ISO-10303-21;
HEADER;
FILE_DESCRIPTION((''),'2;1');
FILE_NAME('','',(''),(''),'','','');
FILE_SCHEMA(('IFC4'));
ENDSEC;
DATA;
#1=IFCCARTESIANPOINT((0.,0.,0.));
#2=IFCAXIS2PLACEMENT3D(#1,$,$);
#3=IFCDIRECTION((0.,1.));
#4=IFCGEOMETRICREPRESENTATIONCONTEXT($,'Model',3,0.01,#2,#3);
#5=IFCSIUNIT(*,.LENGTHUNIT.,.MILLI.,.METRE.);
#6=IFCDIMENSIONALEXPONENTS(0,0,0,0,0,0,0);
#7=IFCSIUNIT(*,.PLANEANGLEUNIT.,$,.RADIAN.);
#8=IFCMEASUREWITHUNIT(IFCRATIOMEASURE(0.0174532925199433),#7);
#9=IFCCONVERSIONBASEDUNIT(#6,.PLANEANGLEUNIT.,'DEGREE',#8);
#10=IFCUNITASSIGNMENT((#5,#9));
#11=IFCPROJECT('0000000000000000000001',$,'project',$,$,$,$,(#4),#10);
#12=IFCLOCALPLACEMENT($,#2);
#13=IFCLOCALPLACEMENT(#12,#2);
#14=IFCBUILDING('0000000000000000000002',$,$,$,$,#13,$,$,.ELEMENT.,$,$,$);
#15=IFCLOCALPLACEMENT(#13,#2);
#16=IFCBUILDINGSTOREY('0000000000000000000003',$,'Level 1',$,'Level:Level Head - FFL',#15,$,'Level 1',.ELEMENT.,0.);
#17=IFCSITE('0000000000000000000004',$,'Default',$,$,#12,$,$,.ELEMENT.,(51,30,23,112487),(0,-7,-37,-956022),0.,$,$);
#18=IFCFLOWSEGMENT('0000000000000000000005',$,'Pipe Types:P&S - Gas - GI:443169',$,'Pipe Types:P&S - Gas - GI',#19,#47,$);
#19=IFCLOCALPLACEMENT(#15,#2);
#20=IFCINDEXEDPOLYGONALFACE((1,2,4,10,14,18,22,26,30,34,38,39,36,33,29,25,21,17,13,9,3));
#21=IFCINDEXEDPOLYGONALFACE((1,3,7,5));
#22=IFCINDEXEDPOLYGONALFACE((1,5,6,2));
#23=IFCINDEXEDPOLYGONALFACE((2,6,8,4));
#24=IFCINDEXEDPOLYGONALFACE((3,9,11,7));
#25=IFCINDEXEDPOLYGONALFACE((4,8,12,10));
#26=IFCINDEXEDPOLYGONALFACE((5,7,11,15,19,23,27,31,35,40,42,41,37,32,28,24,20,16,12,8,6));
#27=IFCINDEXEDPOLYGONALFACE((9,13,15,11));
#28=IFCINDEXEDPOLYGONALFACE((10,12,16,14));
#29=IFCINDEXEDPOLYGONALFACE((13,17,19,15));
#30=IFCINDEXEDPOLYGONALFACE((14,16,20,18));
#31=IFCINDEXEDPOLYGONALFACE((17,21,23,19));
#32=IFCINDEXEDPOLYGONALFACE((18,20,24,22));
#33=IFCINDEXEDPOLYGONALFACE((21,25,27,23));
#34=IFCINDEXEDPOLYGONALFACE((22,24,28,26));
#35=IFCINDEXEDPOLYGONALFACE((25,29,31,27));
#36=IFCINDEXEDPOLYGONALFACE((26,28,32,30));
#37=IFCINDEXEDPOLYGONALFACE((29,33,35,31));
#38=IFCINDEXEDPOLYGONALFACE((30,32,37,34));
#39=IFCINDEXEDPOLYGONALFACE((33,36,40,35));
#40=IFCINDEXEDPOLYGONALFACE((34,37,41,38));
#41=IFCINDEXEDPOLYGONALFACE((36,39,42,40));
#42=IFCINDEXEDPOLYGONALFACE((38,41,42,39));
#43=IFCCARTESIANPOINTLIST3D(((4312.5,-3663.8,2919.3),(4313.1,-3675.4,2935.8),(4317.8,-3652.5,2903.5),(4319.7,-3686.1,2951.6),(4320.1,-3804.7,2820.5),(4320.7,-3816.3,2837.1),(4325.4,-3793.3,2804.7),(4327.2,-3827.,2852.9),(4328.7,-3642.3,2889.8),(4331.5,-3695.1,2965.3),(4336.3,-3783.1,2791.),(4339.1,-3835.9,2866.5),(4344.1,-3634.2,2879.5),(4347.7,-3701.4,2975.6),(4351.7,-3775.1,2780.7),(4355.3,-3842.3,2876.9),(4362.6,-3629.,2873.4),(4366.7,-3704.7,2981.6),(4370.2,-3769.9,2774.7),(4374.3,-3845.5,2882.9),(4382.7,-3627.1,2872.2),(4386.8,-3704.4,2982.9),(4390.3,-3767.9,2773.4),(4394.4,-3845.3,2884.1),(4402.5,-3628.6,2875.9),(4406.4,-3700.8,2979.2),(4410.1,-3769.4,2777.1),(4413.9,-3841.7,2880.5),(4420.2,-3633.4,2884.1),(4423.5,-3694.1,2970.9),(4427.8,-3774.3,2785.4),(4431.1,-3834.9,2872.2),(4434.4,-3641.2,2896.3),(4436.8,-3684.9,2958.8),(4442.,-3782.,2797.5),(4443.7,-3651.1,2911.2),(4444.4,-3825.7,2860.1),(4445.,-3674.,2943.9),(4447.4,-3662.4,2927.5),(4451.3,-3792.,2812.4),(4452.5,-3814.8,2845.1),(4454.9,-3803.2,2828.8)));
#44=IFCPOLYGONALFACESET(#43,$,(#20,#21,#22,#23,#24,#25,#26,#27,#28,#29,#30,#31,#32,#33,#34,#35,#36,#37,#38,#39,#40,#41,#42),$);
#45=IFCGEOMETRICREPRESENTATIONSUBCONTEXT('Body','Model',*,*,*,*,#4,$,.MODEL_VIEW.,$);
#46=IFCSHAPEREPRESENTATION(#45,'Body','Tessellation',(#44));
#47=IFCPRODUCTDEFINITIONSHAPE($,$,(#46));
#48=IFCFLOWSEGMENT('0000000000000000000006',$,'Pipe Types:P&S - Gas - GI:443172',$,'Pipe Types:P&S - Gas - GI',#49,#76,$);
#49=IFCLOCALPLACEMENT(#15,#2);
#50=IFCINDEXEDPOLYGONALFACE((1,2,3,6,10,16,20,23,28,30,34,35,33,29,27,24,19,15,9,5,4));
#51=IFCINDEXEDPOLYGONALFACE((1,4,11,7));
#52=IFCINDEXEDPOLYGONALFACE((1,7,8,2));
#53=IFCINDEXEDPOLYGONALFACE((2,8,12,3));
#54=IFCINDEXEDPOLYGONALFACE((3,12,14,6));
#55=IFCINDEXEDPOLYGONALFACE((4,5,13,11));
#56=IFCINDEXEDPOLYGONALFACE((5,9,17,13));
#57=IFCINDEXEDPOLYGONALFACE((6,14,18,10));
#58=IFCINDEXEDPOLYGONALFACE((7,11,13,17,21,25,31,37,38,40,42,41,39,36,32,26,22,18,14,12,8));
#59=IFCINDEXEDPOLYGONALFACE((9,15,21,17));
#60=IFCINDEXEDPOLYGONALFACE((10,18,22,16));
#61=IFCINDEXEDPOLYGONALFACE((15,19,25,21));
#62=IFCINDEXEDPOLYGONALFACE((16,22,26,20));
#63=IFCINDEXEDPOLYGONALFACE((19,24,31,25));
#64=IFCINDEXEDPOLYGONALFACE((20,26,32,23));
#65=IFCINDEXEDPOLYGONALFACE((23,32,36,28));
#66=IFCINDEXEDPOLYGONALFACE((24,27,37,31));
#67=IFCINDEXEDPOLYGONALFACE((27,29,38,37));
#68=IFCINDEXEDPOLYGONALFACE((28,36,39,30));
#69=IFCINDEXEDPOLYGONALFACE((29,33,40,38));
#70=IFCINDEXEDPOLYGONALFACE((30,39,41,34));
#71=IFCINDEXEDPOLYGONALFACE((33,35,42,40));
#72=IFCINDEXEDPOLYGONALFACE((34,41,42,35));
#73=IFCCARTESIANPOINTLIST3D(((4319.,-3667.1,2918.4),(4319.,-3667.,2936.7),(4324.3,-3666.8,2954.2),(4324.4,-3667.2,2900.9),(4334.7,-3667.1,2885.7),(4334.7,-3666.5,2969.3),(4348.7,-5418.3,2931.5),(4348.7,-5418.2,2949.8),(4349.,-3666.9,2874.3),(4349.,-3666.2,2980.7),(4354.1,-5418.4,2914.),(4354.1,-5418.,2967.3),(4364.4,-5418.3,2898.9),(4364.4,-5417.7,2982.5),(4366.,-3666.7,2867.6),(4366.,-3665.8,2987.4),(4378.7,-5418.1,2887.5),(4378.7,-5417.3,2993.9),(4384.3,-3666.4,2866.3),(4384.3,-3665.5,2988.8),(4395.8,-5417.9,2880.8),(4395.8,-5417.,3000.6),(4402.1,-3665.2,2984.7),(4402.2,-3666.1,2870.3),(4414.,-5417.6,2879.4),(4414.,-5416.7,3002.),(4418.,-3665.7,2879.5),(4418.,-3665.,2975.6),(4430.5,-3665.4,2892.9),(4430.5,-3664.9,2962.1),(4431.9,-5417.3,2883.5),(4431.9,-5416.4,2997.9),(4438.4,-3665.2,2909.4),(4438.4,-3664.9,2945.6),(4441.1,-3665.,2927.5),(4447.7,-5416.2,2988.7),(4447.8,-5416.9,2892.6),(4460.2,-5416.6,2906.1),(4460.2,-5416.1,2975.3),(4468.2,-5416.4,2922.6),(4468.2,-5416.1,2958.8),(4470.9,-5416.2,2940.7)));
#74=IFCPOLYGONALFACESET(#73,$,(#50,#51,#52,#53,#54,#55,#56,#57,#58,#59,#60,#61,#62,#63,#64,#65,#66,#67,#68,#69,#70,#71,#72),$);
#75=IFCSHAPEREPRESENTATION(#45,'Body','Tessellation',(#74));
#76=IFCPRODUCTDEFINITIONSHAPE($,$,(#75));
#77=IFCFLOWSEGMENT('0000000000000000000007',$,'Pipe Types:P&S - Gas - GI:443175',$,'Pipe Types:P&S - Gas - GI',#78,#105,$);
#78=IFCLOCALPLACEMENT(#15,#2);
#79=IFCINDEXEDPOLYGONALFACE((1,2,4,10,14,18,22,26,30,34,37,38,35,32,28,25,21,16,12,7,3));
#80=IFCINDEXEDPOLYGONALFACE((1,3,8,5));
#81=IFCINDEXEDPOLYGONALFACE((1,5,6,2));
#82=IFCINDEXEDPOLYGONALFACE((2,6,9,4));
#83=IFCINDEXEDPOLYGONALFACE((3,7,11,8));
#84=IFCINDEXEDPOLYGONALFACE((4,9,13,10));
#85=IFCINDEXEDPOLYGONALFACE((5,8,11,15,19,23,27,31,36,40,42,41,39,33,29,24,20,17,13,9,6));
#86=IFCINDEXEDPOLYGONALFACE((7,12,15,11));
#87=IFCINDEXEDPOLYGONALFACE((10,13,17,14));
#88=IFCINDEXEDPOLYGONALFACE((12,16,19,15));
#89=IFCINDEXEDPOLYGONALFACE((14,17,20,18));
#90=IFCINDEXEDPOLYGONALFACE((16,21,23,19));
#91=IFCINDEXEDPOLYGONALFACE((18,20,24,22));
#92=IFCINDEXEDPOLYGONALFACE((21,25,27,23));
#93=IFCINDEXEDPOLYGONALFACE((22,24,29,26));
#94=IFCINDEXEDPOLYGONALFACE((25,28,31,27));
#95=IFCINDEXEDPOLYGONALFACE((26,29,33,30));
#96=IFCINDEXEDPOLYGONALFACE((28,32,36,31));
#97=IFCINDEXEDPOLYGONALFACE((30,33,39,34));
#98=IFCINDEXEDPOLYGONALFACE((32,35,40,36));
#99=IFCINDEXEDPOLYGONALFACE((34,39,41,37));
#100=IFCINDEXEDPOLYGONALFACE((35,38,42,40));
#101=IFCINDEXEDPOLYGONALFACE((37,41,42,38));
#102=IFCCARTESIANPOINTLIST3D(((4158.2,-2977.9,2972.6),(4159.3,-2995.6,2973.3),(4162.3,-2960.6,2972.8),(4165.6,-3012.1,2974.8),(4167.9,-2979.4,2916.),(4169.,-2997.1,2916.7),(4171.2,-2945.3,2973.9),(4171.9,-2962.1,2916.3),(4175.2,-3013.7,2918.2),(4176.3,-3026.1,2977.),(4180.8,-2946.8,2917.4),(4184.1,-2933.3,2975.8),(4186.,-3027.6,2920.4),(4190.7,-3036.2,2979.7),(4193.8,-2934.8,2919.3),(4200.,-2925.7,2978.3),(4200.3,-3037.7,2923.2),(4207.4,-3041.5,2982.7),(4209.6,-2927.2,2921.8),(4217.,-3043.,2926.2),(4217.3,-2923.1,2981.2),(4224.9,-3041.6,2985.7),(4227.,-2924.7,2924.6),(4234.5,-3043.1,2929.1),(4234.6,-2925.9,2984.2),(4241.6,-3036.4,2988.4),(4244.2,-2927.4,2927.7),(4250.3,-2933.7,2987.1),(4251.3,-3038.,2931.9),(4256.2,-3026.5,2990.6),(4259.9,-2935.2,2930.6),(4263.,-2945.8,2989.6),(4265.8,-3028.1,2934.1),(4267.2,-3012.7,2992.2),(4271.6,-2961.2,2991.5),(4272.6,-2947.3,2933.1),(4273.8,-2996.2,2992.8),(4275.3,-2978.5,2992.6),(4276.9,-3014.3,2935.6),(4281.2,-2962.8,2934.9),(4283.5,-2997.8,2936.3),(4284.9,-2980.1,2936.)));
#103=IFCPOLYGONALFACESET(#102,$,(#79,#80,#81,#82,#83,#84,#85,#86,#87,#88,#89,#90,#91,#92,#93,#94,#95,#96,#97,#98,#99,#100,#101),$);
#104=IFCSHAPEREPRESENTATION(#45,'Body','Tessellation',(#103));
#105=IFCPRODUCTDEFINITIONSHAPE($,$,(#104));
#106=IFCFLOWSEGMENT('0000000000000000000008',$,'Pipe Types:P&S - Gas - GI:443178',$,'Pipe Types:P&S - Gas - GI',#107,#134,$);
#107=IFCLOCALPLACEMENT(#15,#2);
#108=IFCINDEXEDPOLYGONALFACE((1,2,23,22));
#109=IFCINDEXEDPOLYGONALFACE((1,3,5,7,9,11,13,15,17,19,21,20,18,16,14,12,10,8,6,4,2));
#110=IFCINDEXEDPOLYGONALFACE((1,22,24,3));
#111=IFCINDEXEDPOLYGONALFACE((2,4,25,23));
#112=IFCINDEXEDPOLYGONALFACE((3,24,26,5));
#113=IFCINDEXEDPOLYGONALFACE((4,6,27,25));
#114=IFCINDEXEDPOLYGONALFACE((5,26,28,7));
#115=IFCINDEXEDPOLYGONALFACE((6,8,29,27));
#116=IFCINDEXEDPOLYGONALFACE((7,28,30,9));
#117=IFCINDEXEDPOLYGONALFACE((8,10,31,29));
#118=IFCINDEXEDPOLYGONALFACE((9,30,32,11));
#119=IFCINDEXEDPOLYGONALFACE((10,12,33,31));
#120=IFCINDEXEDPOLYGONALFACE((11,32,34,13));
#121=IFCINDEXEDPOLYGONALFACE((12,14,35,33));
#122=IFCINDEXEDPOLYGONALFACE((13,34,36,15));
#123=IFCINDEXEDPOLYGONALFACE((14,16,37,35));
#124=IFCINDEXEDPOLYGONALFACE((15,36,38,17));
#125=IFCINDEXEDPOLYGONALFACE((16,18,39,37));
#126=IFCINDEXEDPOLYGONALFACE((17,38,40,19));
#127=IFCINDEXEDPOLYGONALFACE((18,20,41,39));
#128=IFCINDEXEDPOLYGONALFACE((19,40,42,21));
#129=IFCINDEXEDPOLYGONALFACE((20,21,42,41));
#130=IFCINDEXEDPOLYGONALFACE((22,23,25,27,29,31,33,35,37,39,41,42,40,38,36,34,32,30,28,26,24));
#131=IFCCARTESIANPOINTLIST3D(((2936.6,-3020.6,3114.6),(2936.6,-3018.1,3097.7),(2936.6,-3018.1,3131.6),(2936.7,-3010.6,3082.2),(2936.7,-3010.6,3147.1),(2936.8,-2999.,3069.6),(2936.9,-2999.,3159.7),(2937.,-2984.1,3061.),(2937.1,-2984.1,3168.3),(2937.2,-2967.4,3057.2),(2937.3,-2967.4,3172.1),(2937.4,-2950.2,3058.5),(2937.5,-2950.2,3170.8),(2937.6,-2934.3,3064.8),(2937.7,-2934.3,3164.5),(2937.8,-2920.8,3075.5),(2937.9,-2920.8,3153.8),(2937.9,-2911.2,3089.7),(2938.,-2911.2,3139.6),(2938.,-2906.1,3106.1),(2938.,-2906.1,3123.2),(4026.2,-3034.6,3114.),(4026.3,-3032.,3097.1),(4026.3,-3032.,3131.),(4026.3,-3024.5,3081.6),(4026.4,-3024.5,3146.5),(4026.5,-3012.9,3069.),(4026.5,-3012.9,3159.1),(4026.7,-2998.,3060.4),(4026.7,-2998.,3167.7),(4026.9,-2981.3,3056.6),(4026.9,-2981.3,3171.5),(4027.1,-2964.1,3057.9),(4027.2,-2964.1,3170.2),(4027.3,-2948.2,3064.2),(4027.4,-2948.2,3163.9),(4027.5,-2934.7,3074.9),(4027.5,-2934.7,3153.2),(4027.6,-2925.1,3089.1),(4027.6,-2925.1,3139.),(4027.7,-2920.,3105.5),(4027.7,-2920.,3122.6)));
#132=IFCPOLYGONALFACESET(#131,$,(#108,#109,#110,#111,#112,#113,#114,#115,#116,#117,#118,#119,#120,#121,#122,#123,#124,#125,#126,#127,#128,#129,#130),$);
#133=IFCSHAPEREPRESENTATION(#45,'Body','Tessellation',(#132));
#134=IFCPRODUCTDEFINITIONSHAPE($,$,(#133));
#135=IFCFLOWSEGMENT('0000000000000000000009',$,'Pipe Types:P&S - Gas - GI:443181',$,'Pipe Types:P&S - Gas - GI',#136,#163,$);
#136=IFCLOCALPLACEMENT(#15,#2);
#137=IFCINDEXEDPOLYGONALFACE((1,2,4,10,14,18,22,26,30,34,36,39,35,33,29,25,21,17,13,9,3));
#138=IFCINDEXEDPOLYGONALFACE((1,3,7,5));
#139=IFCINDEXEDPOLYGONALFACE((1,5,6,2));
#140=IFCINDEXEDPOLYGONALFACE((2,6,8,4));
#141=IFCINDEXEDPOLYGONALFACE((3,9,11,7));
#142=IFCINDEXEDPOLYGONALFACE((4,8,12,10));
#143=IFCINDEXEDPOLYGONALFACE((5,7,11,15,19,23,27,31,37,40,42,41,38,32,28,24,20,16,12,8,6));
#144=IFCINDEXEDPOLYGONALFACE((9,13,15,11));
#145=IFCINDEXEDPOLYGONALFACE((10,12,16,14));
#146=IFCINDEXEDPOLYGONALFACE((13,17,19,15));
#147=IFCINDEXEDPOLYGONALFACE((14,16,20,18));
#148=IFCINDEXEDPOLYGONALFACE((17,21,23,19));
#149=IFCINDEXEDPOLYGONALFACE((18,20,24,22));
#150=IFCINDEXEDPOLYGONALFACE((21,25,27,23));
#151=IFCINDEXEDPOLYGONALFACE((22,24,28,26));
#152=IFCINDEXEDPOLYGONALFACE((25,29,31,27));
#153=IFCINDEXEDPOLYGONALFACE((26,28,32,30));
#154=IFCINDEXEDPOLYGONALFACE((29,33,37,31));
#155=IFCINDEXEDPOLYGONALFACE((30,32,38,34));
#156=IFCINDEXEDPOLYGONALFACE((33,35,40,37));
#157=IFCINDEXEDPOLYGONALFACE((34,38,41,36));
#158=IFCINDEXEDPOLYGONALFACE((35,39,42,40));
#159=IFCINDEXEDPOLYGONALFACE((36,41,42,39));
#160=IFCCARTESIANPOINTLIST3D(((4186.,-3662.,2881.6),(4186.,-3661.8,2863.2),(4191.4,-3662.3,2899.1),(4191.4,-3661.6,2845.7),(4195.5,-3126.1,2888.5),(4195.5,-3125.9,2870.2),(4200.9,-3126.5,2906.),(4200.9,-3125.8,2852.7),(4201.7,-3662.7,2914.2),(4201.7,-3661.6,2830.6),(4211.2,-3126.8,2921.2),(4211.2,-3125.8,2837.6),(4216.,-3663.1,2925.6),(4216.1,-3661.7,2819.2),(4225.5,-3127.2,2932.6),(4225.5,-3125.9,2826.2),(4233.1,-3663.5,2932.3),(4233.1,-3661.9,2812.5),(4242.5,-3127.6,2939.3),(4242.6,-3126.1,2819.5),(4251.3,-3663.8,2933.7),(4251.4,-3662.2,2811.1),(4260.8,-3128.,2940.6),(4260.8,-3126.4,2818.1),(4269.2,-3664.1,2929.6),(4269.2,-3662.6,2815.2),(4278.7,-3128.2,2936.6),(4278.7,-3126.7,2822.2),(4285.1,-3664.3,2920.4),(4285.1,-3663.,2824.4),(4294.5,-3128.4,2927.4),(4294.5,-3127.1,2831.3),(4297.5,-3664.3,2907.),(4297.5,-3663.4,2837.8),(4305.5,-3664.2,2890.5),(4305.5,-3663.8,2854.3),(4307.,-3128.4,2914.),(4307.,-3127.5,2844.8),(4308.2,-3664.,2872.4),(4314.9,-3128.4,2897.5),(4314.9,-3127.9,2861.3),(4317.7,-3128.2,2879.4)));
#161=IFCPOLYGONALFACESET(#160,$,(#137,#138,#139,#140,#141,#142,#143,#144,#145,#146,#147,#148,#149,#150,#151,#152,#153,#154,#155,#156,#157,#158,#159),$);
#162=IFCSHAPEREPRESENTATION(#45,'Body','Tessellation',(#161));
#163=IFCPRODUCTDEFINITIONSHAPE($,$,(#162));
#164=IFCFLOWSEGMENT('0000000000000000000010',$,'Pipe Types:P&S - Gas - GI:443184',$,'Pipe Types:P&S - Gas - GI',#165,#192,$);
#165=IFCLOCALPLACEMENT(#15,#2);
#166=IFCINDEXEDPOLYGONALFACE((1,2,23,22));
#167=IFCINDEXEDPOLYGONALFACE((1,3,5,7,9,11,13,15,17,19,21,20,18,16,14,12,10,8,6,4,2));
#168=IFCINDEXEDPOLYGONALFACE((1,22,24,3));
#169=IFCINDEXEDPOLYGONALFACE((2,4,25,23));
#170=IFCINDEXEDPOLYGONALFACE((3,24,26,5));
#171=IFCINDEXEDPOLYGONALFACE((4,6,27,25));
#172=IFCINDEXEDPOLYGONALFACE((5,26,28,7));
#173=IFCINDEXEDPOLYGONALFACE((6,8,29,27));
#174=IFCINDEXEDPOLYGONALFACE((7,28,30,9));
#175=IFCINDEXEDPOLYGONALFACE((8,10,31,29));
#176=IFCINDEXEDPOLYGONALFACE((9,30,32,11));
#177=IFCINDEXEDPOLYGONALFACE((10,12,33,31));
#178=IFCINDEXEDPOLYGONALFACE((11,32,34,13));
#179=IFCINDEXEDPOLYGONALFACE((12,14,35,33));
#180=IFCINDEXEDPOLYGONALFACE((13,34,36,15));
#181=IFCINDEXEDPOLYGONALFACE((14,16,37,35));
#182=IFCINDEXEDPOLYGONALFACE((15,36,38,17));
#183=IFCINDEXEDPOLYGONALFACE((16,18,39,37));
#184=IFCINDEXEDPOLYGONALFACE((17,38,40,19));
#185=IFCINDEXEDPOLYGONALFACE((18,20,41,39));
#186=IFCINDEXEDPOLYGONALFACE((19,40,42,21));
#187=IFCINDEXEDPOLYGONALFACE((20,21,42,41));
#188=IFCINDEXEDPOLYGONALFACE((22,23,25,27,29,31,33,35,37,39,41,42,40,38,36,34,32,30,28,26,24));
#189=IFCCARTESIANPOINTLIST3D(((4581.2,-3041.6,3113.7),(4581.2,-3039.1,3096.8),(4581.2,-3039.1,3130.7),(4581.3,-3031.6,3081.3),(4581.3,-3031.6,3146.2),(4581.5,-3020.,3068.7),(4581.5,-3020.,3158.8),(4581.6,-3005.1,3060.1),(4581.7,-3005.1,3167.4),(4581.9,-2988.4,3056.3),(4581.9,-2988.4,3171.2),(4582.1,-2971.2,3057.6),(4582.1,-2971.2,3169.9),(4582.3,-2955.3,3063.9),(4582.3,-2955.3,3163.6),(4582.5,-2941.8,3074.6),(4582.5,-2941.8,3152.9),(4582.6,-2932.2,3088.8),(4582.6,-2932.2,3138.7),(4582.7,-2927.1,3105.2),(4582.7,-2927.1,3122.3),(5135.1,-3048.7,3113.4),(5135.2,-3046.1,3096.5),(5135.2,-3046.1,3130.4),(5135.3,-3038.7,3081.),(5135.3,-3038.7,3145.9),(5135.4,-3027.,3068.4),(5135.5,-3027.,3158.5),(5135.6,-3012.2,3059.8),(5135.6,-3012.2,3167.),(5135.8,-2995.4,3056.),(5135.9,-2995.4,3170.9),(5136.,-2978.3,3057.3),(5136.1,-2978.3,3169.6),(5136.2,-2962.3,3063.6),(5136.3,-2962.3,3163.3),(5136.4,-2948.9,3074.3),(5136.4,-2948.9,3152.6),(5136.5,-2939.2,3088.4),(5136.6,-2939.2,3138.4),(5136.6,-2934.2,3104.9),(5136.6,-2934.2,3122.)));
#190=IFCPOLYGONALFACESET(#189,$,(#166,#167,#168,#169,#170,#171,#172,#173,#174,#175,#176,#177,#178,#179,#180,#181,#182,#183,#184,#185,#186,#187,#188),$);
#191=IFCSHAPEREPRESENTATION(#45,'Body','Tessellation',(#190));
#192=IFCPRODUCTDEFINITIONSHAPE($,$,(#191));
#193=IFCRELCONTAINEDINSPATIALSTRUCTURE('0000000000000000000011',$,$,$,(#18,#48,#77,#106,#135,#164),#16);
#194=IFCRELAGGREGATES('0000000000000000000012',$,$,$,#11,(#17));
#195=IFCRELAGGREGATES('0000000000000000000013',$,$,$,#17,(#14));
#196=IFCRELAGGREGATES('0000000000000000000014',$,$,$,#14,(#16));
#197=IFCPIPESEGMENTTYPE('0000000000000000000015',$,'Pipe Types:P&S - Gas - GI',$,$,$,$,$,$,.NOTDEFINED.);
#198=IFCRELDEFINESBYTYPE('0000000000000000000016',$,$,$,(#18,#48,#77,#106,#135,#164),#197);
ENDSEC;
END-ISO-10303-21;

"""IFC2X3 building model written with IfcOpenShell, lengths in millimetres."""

from ifc_helpers import new_model, entity, si_unit, converted_unit, direction, frame, frame_2d, origin, origin_2d_with_axis, place, context, subcontext, project, spatial, circle, extrude, type_object, element, save


model = new_model("IFC2X3")

# Units and contexts
model_context = context("Model", 3, precision=0.01, world=origin(), true_north=direction((0.0, 1.0)))
body_context = subcontext(model_context, "Body", "Model", "MODEL_VIEW")
ifc_project = project(units=[si_unit("LENGTHUNIT", "METRE", prefix="MILLI"), converted_unit("PLANEANGLEUNIT", "DEGREE", entity("IfcRatioMeasure", 0.0174532925199433), si_unit("PLANEANGLEUNIT", "RADIAN"), dimensions=[0, 0, 0, 0, 0, 0, 0])], contexts=[model_context])

# Site, building, storey
site_placement = place(None, origin())
site = spatial("IfcSite", under=ifc_project, at=site_placement, Name="Default", CompositionType="ELEMENT", RefLatitude=(51, 30, 23, 112487), RefLongitude=(0, -7, -37, -956022), RefElevation=0.0)
building_placement = place(site_placement, origin())
building = spatial("IfcBuilding", under=site, at=building_placement, CompositionType="ELEMENT")
storey_placement = place(building_placement, origin())
storey = spatial("IfcBuildingStorey", under=building, at=storey_placement, Name="Level 1", ObjectType="Level:Level Head - FFL", LongName="Level 1", CompositionType="ELEMENT", Elevation=0.0)

# Flow segments
pipe_segment_type = type_object("IfcPipeSegmentType", Name="Pipe Types:P&S - Gas - GI", PredefinedType="NOTDEFINED")
flow_segment_1_placement = place(storey_placement, origin())
element("IfcFlowSegment", 1, at=flow_segment_1_placement, inside=storey, type_object=pipe_segment_type, Name="Pipe Types:P&S - Gas - GI:443169", ObjectType="Pipe Types:P&S - Gas - GI", context=body_context, shape_type="SweptSolid", body=[
    extrude(circle(Radius=67.7, at=frame_2d((0.0, 0.0), x_axis=(1.0, 0.0))), frame((4379.7, -3666.0, 2927.5), z_axis=(0.044048, -0.818004, -0.573523), x_axis=(0.998553, 0.053771, 0.0)), (0.0, 0.0, 1.0), 172.2),
])
flow_segment_2_placement = place(storey_placement, origin())
element("IfcFlowSegment", 2, at=flow_segment_2_placement, inside=storey, type_object=pipe_segment_type, Name="Pipe Types:P&S - Gas - GI:443172", ObjectType="Pipe Types:P&S - Gas - GI", context=body_context, shape_type="SweptSolid", body=[
    extrude(circle(Radius=61.4, at=origin_2d_with_axis()), frame((4379.7, -3666.0, 2927.5), z_axis=(0.016983, -0.999828, 0.007503), x_axis=(0.999856, 0.016983, 0.0)), (0.0, 0.0, 1.0), 1751.5),
])
flow_segment_3_placement = place(storey_placement, origin())
element("IfcFlowSegment", 3, at=flow_segment_3_placement, inside=storey, type_object=pipe_segment_type, Name="Pipe Types:P&S - Gas - GI:443175", ObjectType="Pipe Types:P&S - Gas - GI", context=body_context, shape_type="SweptSolid", body=[
    extrude(circle(Radius=59.6, at=origin_2d_with_axis()), frame((4226.4, -2984.2, 2926.2), z_axis=(-0.168294, 0.026726, 0.985374), x_axis=(-0.156842, -0.987624, 0.0)), (0.0, 0.0, 1.0), 57.4),
])
flow_segment_4_placement = place(storey_placement, origin())
element("IfcFlowSegment", 4, at=flow_segment_4_placement, inside=storey, type_object=pipe_segment_type, Name="Pipe Types:P&S - Gas - GI:443178", ObjectType="Pipe Types:P&S - Gas - GI", context=body_context, shape_type="SweptSolid", body=[
    extrude(circle(Radius=57.6, at=origin_2d_with_axis()), frame((2937.3, -2963.1, 3114.6), z_axis=(0.999918, -0.012764, -0.000549), x_axis=(-0.012764, -0.999919, 0.0)), (0.0, 0.0, 1.0), 1089.8),
])
flow_segment_5_placement = place(storey_placement, origin())
element("IfcFlowSegment", 5, at=flow_segment_5_placement, inside=storey, type_object=pipe_segment_type, Name="Pipe Types:P&S - Gas - GI:443181", ObjectType="Pipe Types:P&S - Gas - GI", context=body_context, shape_type="SweptSolid", body=[
    extrude(circle(Radius=61.4, at=frame_2d((0.0, 0.0), x_axis=(1.0, 0.0))), frame((4246.8, -3663.0, 2872.4), z_axis=(0.017646, 0.99976, 0.013021), x_axis=(0.999844, -0.017648, 0.0)), (0.0, 0.0, 1.0), 536.0),
])
flow_segment_6_placement = place(storey_placement, origin())
element("IfcFlowSegment", 6, at=flow_segment_6_placement, inside=storey, type_object=pipe_segment_type, Name="Pipe Types:P&S - Gas - GI:443184", ObjectType="Pipe Types:P&S - Gas - GI", context=body_context, shape_type="SweptSolid", body=[
    extrude(circle(Radius=57.6, at=origin_2d_with_axis()), frame((4581.9, -2984.0, 3113.7), z_axis=(0.999918, -0.012764, -0.000549), x_axis=(-0.012764, -0.999919, 0.0)), (0.0, 0.0, 1.0), 554.0),
])

save(model, "model.ifc")
